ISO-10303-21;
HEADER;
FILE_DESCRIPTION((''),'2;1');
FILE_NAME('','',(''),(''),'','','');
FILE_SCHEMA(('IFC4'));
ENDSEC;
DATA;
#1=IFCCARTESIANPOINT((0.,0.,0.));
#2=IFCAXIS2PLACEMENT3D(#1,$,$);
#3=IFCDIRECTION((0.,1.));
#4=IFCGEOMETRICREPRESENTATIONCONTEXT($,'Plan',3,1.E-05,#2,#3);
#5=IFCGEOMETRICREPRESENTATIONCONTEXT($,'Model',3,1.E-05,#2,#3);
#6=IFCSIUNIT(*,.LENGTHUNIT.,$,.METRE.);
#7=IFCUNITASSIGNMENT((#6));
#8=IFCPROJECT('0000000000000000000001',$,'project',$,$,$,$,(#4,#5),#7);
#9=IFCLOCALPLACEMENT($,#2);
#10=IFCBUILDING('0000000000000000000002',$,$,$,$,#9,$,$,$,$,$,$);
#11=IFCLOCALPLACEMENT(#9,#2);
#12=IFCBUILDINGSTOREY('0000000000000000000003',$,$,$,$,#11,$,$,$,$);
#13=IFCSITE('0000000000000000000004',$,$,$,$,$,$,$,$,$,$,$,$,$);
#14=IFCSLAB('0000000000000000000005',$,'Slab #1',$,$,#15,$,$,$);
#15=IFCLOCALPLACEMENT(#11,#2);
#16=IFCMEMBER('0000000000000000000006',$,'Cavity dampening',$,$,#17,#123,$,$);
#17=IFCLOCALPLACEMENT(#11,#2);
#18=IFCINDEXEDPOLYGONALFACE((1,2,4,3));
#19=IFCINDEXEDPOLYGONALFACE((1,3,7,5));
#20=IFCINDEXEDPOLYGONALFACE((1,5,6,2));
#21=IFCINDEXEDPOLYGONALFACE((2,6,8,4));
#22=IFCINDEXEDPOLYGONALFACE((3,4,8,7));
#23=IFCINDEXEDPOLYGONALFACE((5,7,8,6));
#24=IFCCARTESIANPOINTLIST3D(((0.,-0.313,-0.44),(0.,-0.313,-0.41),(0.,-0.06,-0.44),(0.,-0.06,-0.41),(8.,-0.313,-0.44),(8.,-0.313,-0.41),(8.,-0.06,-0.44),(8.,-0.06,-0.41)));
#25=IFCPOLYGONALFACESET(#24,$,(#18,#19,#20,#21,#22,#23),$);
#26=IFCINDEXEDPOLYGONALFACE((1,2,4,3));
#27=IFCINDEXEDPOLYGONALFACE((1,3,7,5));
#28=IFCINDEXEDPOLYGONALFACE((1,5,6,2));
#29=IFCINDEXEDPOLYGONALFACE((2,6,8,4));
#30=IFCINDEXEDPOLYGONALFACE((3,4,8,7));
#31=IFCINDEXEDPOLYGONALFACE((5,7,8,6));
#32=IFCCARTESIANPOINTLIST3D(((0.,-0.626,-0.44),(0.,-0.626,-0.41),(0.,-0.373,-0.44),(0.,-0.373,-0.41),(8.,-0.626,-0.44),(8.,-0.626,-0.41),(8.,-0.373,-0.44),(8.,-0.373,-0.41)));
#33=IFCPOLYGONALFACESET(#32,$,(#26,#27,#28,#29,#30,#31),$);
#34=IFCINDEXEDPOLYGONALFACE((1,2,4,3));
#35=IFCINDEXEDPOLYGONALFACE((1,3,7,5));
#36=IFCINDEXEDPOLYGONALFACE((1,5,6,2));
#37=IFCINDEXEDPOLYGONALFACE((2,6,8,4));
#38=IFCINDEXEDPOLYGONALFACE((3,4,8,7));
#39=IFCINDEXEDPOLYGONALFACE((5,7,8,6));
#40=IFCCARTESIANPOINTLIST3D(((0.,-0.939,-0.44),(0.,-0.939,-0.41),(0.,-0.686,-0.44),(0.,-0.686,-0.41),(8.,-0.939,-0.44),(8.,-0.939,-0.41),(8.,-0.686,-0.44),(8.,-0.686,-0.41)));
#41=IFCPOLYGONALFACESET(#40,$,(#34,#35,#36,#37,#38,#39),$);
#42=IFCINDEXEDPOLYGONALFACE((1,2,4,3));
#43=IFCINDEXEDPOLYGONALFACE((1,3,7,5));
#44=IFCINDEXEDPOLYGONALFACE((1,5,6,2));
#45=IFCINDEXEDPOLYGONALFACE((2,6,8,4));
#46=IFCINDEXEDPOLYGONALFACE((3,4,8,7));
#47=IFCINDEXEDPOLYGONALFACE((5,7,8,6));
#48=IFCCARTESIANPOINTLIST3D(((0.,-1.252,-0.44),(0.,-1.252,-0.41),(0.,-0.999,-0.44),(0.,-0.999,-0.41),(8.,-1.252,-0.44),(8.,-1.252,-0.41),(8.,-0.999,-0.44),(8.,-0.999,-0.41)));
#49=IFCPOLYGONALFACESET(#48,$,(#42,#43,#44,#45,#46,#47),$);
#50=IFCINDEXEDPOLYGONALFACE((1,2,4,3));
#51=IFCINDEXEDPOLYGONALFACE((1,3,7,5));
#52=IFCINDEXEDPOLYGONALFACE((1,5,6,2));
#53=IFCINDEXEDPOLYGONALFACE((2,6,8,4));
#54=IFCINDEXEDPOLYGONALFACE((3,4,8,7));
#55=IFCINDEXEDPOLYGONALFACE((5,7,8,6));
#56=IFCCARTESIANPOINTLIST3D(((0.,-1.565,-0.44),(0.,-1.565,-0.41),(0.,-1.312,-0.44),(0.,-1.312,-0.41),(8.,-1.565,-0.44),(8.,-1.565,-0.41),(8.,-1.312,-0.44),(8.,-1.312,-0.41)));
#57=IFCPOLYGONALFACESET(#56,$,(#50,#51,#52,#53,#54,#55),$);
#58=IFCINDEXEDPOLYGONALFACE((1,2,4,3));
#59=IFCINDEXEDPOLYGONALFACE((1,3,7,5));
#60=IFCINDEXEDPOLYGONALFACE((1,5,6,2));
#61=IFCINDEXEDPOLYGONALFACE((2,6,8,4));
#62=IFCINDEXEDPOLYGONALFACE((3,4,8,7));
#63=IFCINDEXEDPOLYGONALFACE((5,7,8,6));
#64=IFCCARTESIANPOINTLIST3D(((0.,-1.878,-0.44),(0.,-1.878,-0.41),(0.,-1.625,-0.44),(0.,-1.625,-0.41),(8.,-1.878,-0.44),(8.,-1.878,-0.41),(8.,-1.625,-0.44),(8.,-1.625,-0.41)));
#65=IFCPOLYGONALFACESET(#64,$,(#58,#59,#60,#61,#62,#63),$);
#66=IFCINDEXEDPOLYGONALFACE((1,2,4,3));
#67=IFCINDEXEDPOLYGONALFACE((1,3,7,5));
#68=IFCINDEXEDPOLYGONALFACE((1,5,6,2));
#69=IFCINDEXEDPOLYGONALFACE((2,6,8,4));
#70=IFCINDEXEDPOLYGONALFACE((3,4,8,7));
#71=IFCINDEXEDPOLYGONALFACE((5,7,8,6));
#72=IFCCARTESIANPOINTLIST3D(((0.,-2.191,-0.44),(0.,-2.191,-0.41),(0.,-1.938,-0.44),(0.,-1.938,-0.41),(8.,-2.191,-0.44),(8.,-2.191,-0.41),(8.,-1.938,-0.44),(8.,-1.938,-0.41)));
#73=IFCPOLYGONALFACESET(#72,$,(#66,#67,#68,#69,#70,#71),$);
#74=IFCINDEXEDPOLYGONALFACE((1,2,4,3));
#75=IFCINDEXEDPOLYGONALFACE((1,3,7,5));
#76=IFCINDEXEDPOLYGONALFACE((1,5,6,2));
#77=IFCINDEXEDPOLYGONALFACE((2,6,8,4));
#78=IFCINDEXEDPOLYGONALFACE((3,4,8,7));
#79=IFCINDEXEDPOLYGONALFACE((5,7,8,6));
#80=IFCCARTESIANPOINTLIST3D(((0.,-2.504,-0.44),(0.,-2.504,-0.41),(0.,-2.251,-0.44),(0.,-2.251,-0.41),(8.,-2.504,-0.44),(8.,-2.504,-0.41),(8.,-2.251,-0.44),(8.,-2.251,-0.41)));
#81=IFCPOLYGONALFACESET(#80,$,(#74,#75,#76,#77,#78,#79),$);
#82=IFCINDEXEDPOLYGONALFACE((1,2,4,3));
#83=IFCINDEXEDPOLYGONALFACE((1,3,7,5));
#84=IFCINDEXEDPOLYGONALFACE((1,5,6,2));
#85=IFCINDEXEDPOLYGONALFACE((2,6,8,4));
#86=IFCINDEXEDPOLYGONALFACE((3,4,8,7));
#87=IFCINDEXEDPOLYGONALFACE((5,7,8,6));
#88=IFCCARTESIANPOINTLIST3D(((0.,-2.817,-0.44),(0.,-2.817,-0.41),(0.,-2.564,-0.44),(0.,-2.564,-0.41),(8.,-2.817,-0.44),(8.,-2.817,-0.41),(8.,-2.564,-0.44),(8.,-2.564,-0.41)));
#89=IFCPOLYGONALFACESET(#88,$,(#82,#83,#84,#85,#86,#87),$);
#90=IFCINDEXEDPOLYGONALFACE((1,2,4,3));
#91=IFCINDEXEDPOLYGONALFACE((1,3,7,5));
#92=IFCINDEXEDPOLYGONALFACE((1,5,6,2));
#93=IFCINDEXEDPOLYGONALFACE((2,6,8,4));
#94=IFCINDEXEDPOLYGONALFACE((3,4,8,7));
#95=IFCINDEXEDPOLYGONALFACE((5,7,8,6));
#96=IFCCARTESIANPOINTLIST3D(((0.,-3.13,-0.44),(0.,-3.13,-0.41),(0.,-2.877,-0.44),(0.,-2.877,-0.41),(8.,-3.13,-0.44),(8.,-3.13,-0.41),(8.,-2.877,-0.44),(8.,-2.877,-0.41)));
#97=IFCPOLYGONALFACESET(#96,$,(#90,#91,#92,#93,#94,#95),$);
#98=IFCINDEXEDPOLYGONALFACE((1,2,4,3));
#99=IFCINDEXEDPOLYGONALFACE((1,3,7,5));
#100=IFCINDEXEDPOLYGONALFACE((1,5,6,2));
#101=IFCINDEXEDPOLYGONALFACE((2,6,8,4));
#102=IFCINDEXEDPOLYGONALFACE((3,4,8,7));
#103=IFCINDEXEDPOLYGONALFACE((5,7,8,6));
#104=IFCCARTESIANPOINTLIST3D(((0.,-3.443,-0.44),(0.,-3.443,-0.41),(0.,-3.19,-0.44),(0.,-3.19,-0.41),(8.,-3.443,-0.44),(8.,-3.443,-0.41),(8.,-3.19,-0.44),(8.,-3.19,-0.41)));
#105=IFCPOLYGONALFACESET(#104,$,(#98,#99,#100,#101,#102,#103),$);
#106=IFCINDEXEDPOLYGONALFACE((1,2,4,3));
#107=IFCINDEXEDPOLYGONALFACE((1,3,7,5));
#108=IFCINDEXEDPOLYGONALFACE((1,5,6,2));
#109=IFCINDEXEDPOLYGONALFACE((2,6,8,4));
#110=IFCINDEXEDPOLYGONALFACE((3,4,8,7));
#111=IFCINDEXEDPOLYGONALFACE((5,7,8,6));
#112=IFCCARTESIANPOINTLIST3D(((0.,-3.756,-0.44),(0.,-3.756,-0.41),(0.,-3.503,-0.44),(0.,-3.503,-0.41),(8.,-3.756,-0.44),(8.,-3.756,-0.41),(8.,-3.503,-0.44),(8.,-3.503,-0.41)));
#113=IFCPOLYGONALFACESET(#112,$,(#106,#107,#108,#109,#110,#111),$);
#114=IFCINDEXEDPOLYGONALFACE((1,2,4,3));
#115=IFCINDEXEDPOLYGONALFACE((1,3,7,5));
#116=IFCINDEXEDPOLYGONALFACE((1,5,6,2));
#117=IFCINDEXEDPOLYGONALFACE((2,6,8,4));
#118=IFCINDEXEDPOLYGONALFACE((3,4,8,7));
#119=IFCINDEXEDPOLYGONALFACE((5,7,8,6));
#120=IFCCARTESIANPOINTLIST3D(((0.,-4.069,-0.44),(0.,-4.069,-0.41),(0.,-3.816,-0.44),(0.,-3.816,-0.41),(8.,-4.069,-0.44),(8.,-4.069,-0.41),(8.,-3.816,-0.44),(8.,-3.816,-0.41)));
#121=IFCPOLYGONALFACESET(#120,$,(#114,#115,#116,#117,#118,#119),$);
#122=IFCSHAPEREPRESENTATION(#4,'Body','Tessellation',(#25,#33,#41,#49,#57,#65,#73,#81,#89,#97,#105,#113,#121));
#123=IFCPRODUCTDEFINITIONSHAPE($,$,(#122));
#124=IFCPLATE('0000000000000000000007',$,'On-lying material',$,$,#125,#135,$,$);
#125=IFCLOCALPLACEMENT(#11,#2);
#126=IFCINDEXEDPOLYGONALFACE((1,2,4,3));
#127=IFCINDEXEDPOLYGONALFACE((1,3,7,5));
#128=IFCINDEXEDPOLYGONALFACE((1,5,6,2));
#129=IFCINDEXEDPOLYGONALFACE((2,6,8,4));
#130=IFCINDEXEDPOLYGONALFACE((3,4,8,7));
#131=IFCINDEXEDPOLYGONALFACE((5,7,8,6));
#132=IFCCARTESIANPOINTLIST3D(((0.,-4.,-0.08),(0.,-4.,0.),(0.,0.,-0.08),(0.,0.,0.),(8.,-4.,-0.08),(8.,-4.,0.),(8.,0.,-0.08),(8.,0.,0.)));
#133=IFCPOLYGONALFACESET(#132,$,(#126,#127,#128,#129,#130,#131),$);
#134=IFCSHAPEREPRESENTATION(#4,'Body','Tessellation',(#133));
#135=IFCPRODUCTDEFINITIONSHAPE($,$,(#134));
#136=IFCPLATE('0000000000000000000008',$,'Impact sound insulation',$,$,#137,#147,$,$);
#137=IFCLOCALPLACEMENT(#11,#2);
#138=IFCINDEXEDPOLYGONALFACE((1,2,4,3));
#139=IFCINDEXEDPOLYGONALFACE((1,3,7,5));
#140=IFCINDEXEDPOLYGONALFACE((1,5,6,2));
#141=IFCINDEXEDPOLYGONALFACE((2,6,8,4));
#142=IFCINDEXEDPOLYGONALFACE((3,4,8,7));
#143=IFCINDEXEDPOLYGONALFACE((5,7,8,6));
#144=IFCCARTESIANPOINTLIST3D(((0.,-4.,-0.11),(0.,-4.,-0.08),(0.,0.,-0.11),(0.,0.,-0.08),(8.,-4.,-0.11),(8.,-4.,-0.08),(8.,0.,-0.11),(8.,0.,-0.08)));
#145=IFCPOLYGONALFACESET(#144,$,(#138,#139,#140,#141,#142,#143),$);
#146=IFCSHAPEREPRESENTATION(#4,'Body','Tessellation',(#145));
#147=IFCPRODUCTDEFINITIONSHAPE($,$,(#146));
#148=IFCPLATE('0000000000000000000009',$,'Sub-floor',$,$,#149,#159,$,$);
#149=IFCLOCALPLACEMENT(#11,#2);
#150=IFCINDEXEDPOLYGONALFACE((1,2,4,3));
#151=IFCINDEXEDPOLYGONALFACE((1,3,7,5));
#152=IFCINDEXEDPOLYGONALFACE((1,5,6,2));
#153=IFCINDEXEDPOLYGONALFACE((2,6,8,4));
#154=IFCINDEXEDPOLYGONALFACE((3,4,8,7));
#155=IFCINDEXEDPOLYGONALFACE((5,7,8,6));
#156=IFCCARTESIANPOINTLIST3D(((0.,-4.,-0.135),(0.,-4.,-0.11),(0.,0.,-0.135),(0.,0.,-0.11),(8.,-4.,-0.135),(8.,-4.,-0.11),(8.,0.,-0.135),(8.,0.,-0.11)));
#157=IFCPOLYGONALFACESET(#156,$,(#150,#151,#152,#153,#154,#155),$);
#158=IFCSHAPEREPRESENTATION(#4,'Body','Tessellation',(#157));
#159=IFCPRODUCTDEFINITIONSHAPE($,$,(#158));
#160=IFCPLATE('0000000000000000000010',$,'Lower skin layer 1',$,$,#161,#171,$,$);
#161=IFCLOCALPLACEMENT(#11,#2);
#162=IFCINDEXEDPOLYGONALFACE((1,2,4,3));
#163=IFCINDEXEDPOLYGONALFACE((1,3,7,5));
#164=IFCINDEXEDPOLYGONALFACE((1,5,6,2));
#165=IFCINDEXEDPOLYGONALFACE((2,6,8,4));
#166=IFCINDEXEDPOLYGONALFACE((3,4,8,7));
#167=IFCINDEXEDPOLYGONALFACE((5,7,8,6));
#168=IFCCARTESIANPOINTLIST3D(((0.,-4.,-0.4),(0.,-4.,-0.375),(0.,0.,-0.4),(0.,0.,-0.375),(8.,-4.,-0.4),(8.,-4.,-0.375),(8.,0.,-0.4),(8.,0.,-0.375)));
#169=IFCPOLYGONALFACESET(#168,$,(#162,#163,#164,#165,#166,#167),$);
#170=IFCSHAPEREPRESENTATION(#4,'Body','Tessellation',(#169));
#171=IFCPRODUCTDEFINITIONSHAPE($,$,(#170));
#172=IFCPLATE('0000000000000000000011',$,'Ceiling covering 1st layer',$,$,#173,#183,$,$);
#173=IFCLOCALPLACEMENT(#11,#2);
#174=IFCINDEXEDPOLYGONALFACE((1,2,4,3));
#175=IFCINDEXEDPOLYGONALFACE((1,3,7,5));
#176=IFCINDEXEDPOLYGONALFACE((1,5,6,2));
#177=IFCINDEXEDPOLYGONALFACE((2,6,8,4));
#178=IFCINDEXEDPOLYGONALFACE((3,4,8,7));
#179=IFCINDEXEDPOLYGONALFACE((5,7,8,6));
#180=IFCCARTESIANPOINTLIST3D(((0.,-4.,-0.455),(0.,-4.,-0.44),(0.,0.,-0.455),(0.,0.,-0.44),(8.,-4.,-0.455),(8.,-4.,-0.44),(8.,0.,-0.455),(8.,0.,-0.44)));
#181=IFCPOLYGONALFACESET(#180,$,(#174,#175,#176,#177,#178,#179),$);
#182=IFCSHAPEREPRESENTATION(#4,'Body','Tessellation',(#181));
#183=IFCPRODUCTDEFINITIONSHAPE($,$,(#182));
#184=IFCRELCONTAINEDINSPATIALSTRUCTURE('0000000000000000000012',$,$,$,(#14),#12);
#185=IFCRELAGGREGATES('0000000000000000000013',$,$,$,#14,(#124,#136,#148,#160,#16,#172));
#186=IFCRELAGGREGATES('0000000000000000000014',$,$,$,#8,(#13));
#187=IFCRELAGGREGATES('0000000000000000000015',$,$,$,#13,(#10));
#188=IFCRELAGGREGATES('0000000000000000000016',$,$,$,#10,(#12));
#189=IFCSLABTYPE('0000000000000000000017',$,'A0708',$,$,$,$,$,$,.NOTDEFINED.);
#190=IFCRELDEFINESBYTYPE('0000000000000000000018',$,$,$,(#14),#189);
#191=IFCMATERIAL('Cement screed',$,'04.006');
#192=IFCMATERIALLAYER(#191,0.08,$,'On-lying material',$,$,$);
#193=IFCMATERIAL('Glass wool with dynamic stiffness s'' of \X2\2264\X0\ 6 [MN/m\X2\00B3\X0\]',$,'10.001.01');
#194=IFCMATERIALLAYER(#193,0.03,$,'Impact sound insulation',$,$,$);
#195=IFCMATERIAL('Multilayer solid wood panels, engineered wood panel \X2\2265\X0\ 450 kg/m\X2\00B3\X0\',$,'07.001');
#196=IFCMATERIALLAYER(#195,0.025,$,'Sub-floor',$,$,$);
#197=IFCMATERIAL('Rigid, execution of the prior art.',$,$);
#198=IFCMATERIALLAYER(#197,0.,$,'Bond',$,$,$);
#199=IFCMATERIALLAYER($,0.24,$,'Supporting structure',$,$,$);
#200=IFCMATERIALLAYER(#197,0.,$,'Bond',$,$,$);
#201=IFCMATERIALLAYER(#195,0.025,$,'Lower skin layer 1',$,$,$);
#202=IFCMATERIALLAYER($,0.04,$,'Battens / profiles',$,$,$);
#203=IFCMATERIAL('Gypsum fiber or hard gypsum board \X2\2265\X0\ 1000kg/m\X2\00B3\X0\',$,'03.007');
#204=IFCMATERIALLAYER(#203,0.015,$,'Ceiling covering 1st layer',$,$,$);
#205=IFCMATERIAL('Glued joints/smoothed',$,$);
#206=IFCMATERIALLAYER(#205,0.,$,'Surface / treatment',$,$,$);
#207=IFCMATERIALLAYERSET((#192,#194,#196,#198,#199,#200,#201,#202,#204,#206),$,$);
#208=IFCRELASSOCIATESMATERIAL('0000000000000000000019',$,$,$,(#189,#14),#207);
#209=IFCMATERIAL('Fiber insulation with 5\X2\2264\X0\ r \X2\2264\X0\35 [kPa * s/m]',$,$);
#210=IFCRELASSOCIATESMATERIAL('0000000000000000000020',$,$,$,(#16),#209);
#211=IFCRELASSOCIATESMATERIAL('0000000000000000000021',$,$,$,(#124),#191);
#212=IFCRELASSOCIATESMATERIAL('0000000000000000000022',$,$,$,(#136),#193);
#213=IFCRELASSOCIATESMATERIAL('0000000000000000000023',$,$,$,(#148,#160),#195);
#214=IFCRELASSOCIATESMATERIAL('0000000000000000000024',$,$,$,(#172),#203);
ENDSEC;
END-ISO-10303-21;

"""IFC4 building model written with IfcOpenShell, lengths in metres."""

from ifc_helpers import new_model, si_unit, direction, frame, frame_2d, origin, origin_with_axes, place, context, project, spatial, rectangle, extrude, material, layer, layer_set, type_object, element, aggregate, save


model = new_model("IFC4")

# Units and contexts
plan_context = context("Plan", 3, precision=1e-05, world=origin(), true_north=direction((0.0, 1.0)))
model_context = context("Model", 3, precision=1e-05, world=origin(), true_north=direction((0.0, 1.0)))
ifc_project = project(units=[si_unit("LENGTHUNIT", "METRE")], contexts=[plan_context, model_context])

# Site, building, storey
site = spatial("IfcSite", under=ifc_project)
building_placement = place(None, origin())
building = spatial("IfcBuilding", under=site, at=building_placement)
storey_placement = place(building_placement, origin())
storey = spatial("IfcBuildingStorey", under=building, at=storey_placement)

# Slab, member, plates
ifc_material_1 = material(Name="Cement screed", Category="04.006")
ifc_layer_1 = layer(ifc_material_1, 0.08, Name="On-lying material")
ifc_material_2 = material(Name="Glass wool with dynamic stiffness s' of ≤ 6 [MN/m³]", Category="10.001.01")
ifc_layer_2 = layer(ifc_material_2, 0.03, Name="Impact sound insulation")
ifc_material_3 = material(Name="Multilayer solid wood panels, engineered wood panel ≥ 450 kg/m³", Category="07.001")
ifc_layer_3 = layer(ifc_material_3, 0.025, Name="Sub-floor")
ifc_material_4 = material(Name="Rigid, execution of the prior art.")
ifc_layer_4 = layer(ifc_material_4, 0.0, Name="Bond")
ifc_layer_5 = layer(None, 0.24, Name="Supporting structure")
ifc_layer_6 = layer(ifc_material_4, 0.0, Name="Bond")
ifc_layer_7 = layer(ifc_material_3, 0.025, Name="Lower skin layer 1")
ifc_layer_8 = layer(None, 0.04, Name="Battens / profiles")
ifc_material_5 = material(Name="Gypsum fiber or hard gypsum board ≥ 1000kg/m³", Category="03.007")
ifc_layer_9 = layer(ifc_material_5, 0.015, Name="Ceiling covering 1st layer")
ifc_material_6 = material(Name="Glued joints/smoothed")
ifc_layer_10 = layer(ifc_material_6, 0.0, Name="Surface / treatment")
ifc_layer_set = layer_set([ifc_layer_1, ifc_layer_2, ifc_layer_3, ifc_layer_4, ifc_layer_5, ifc_layer_6, ifc_layer_7, ifc_layer_8, ifc_layer_9, ifc_layer_10])
slab_type = type_object("IfcSlabType", Name="A0708", PredefinedType="NOTDEFINED", material=ifc_layer_set)
slab_placement = place(None, frame((0.0, 0.0, 0.0), z_axis=(0.0, 0.0, -1.0), x_axis=(1.0, 0.0, 0.0)))
slab = element("IfcSlab", 1, at=slab_placement, inside=storey, type_object=slab_type, material=ifc_layer_set, Name="Slab #1")
ifc_material_7 = material(Name="Fiber insulation with 5≤ r ≤35 [kPa * s/m]")
member_1_placement = place(slab_placement, origin())
member_1 = element("IfcMember", 2, at=member_1_placement, material=ifc_material_7, Name="Cavity dampening", context=plan_context, shape_type="SweptSolid", body=[
    extrude(rectangle(XDim=0.253, YDim=0.03, at=frame_2d((0.1265, 0.015), x_axis=(1.0, 0.0))), frame((0.0, 0.06, 0.41), z_axis=(1.0, 0.0, 0.0), x_axis=(0.0, 1.0, 0.0)), (0.0, 0.0, 1.0), 8.0),
    extrude(rectangle(XDim=0.253, YDim=0.03, at=frame_2d((0.1265, 0.015), x_axis=(1.0, 0.0))), frame((0.0, 0.373, 0.41), z_axis=(1.0, 0.0, 0.0), x_axis=(0.0, 1.0, 0.0)), (0.0, 0.0, 1.0), 8.0),
    extrude(rectangle(XDim=0.253, YDim=0.03, at=frame_2d((0.1265, 0.015), x_axis=(1.0, 0.0))), frame((0.0, 0.686, 0.41), z_axis=(1.0, 0.0, 0.0), x_axis=(0.0, 1.0, 0.0)), (0.0, 0.0, 1.0), 8.0),
    extrude(rectangle(XDim=0.253, YDim=0.03, at=frame_2d((0.1265, 0.015), x_axis=(1.0, 0.0))), frame((0.0, 0.999, 0.41), z_axis=(1.0, 0.0, 0.0), x_axis=(0.0, 1.0, 0.0)), (0.0, 0.0, 1.0), 8.0),
    extrude(rectangle(XDim=0.253, YDim=0.03, at=frame_2d((0.1265, 0.015), x_axis=(1.0, 0.0))), frame((0.0, 1.312, 0.41), z_axis=(1.0, 0.0, 0.0), x_axis=(0.0, 1.0, 0.0)), (0.0, 0.0, 1.0), 8.0),
    extrude(rectangle(XDim=0.253, YDim=0.03, at=frame_2d((0.1265, 0.015), x_axis=(1.0, 0.0))), frame((0.0, 1.625, 0.41), z_axis=(1.0, 0.0, 0.0), x_axis=(0.0, 1.0, 0.0)), (0.0, 0.0, 1.0), 8.0),
    extrude(rectangle(XDim=0.253, YDim=0.03, at=frame_2d((0.1265, 0.015), x_axis=(1.0, 0.0))), frame((0.0, 1.938, 0.41), z_axis=(1.0, 0.0, 0.0), x_axis=(0.0, 1.0, 0.0)), (0.0, 0.0, 1.0), 8.0),
    extrude(rectangle(XDim=0.253, YDim=0.03, at=frame_2d((0.1265, 0.015), x_axis=(1.0, 0.0))), frame((0.0, 2.251, 0.41), z_axis=(1.0, 0.0, 0.0), x_axis=(0.0, 1.0, 0.0)), (0.0, 0.0, 1.0), 8.0),
    extrude(rectangle(XDim=0.253, YDim=0.03, at=frame_2d((0.1265, 0.015), x_axis=(1.0, 0.0))), frame((0.0, 2.564, 0.41), z_axis=(1.0, 0.0, 0.0), x_axis=(0.0, 1.0, 0.0)), (0.0, 0.0, 1.0), 8.0),
    extrude(rectangle(XDim=0.253, YDim=0.03, at=frame_2d((0.1265, 0.015), x_axis=(1.0, 0.0))), frame((0.0, 2.877, 0.41), z_axis=(1.0, 0.0, 0.0), x_axis=(0.0, 1.0, 0.0)), (0.0, 0.0, 1.0), 8.0),
    extrude(rectangle(XDim=0.253, YDim=0.03, at=frame_2d((0.1265, 0.015), x_axis=(1.0, 0.0))), frame((0.0, 3.19, 0.41), z_axis=(1.0, 0.0, 0.0), x_axis=(0.0, 1.0, 0.0)), (0.0, 0.0, 1.0), 8.0),
    extrude(rectangle(XDim=0.253, YDim=0.03, at=frame_2d((0.1265, 0.015), x_axis=(1.0, 0.0))), frame((0.0, 3.503, 0.41), z_axis=(1.0, 0.0, 0.0), x_axis=(0.0, 1.0, 0.0)), (0.0, 0.0, 1.0), 8.0),
    extrude(rectangle(XDim=0.253, YDim=0.03, at=frame_2d((0.1265, 0.015), x_axis=(1.0, 0.0))), frame((0.0, 3.816, 0.41), z_axis=(1.0, 0.0, 0.0), x_axis=(0.0, 1.0, 0.0)), (0.0, 0.0, 1.0), 8.0),
])
plate_1_placement = place(slab_placement, origin())
plate_1 = element("IfcPlate", 3, at=plate_1_placement, material=ifc_material_1, Name="On-lying material", context=plan_context, shape_type="SweptSolid", body=[
    extrude(rectangle(XDim=8.0, YDim=4.0, at=frame_2d((4.0, 2.0), x_axis=(1.0, 0.0))), origin_with_axes(), (0.0, 0.0, 1.0), 0.08),
])
plate_2_placement = place(slab_placement, origin())
plate_2 = element("IfcPlate", 4, at=plate_2_placement, material=ifc_material_2, Name="Impact sound insulation", context=plan_context, shape_type="SweptSolid", body=[
    extrude(rectangle(XDim=8.0, YDim=4.0, at=frame_2d((4.0, 2.0), x_axis=(1.0, 0.0))), frame((0.0, 0.0, 0.08), z_axis=(0.0, 0.0, 1.0), x_axis=(1.0, 0.0, 0.0)), (0.0, 0.0, 1.0), 0.03),
])
plate_3_placement = place(slab_placement, origin())
plate_3 = element("IfcPlate", 5, at=plate_3_placement, material=ifc_material_3, Name="Sub-floor", context=plan_context, shape_type="SweptSolid", body=[
    extrude(rectangle(XDim=8.0, YDim=4.0, at=frame_2d((4.0, 2.0), x_axis=(1.0, 0.0))), frame((0.0, 0.0, 0.11), z_axis=(0.0, 0.0, 1.0), x_axis=(1.0, 0.0, 0.0)), (0.0, 0.0, 1.0), 0.025),
])
plate_4_placement = place(slab_placement, origin())
plate_4 = element("IfcPlate", 6, at=plate_4_placement, material=ifc_material_3, Name="Lower skin layer 1", context=plan_context, shape_type="SweptSolid", body=[
    extrude(rectangle(XDim=8.0, YDim=4.0, at=frame_2d((4.0, 2.0), x_axis=(1.0, 0.0))), frame((0.0, 0.0, 0.375), z_axis=(0.0, 0.0, 1.0), x_axis=(1.0, 0.0, 0.0)), (0.0, 0.0, 1.0), 0.025),
])
plate_5_placement = place(slab_placement, origin())
plate_5 = element("IfcPlate", 7, at=plate_5_placement, material=ifc_material_5, Name="Ceiling covering 1st layer", context=plan_context, shape_type="SweptSolid", body=[
    extrude(rectangle(XDim=8.0, YDim=4.0, at=frame_2d((4.0, 2.0), x_axis=(1.0, 0.0))), frame((0.0, 0.0, 0.44), z_axis=(0.0, 0.0, 1.0), x_axis=(1.0, 0.0, 0.0)), (0.0, 0.0, 1.0), 0.015),
])
aggregate(slab, [plate_1, plate_2, plate_3, plate_4, member_1, plate_5])

save(model, "model.ifc")
